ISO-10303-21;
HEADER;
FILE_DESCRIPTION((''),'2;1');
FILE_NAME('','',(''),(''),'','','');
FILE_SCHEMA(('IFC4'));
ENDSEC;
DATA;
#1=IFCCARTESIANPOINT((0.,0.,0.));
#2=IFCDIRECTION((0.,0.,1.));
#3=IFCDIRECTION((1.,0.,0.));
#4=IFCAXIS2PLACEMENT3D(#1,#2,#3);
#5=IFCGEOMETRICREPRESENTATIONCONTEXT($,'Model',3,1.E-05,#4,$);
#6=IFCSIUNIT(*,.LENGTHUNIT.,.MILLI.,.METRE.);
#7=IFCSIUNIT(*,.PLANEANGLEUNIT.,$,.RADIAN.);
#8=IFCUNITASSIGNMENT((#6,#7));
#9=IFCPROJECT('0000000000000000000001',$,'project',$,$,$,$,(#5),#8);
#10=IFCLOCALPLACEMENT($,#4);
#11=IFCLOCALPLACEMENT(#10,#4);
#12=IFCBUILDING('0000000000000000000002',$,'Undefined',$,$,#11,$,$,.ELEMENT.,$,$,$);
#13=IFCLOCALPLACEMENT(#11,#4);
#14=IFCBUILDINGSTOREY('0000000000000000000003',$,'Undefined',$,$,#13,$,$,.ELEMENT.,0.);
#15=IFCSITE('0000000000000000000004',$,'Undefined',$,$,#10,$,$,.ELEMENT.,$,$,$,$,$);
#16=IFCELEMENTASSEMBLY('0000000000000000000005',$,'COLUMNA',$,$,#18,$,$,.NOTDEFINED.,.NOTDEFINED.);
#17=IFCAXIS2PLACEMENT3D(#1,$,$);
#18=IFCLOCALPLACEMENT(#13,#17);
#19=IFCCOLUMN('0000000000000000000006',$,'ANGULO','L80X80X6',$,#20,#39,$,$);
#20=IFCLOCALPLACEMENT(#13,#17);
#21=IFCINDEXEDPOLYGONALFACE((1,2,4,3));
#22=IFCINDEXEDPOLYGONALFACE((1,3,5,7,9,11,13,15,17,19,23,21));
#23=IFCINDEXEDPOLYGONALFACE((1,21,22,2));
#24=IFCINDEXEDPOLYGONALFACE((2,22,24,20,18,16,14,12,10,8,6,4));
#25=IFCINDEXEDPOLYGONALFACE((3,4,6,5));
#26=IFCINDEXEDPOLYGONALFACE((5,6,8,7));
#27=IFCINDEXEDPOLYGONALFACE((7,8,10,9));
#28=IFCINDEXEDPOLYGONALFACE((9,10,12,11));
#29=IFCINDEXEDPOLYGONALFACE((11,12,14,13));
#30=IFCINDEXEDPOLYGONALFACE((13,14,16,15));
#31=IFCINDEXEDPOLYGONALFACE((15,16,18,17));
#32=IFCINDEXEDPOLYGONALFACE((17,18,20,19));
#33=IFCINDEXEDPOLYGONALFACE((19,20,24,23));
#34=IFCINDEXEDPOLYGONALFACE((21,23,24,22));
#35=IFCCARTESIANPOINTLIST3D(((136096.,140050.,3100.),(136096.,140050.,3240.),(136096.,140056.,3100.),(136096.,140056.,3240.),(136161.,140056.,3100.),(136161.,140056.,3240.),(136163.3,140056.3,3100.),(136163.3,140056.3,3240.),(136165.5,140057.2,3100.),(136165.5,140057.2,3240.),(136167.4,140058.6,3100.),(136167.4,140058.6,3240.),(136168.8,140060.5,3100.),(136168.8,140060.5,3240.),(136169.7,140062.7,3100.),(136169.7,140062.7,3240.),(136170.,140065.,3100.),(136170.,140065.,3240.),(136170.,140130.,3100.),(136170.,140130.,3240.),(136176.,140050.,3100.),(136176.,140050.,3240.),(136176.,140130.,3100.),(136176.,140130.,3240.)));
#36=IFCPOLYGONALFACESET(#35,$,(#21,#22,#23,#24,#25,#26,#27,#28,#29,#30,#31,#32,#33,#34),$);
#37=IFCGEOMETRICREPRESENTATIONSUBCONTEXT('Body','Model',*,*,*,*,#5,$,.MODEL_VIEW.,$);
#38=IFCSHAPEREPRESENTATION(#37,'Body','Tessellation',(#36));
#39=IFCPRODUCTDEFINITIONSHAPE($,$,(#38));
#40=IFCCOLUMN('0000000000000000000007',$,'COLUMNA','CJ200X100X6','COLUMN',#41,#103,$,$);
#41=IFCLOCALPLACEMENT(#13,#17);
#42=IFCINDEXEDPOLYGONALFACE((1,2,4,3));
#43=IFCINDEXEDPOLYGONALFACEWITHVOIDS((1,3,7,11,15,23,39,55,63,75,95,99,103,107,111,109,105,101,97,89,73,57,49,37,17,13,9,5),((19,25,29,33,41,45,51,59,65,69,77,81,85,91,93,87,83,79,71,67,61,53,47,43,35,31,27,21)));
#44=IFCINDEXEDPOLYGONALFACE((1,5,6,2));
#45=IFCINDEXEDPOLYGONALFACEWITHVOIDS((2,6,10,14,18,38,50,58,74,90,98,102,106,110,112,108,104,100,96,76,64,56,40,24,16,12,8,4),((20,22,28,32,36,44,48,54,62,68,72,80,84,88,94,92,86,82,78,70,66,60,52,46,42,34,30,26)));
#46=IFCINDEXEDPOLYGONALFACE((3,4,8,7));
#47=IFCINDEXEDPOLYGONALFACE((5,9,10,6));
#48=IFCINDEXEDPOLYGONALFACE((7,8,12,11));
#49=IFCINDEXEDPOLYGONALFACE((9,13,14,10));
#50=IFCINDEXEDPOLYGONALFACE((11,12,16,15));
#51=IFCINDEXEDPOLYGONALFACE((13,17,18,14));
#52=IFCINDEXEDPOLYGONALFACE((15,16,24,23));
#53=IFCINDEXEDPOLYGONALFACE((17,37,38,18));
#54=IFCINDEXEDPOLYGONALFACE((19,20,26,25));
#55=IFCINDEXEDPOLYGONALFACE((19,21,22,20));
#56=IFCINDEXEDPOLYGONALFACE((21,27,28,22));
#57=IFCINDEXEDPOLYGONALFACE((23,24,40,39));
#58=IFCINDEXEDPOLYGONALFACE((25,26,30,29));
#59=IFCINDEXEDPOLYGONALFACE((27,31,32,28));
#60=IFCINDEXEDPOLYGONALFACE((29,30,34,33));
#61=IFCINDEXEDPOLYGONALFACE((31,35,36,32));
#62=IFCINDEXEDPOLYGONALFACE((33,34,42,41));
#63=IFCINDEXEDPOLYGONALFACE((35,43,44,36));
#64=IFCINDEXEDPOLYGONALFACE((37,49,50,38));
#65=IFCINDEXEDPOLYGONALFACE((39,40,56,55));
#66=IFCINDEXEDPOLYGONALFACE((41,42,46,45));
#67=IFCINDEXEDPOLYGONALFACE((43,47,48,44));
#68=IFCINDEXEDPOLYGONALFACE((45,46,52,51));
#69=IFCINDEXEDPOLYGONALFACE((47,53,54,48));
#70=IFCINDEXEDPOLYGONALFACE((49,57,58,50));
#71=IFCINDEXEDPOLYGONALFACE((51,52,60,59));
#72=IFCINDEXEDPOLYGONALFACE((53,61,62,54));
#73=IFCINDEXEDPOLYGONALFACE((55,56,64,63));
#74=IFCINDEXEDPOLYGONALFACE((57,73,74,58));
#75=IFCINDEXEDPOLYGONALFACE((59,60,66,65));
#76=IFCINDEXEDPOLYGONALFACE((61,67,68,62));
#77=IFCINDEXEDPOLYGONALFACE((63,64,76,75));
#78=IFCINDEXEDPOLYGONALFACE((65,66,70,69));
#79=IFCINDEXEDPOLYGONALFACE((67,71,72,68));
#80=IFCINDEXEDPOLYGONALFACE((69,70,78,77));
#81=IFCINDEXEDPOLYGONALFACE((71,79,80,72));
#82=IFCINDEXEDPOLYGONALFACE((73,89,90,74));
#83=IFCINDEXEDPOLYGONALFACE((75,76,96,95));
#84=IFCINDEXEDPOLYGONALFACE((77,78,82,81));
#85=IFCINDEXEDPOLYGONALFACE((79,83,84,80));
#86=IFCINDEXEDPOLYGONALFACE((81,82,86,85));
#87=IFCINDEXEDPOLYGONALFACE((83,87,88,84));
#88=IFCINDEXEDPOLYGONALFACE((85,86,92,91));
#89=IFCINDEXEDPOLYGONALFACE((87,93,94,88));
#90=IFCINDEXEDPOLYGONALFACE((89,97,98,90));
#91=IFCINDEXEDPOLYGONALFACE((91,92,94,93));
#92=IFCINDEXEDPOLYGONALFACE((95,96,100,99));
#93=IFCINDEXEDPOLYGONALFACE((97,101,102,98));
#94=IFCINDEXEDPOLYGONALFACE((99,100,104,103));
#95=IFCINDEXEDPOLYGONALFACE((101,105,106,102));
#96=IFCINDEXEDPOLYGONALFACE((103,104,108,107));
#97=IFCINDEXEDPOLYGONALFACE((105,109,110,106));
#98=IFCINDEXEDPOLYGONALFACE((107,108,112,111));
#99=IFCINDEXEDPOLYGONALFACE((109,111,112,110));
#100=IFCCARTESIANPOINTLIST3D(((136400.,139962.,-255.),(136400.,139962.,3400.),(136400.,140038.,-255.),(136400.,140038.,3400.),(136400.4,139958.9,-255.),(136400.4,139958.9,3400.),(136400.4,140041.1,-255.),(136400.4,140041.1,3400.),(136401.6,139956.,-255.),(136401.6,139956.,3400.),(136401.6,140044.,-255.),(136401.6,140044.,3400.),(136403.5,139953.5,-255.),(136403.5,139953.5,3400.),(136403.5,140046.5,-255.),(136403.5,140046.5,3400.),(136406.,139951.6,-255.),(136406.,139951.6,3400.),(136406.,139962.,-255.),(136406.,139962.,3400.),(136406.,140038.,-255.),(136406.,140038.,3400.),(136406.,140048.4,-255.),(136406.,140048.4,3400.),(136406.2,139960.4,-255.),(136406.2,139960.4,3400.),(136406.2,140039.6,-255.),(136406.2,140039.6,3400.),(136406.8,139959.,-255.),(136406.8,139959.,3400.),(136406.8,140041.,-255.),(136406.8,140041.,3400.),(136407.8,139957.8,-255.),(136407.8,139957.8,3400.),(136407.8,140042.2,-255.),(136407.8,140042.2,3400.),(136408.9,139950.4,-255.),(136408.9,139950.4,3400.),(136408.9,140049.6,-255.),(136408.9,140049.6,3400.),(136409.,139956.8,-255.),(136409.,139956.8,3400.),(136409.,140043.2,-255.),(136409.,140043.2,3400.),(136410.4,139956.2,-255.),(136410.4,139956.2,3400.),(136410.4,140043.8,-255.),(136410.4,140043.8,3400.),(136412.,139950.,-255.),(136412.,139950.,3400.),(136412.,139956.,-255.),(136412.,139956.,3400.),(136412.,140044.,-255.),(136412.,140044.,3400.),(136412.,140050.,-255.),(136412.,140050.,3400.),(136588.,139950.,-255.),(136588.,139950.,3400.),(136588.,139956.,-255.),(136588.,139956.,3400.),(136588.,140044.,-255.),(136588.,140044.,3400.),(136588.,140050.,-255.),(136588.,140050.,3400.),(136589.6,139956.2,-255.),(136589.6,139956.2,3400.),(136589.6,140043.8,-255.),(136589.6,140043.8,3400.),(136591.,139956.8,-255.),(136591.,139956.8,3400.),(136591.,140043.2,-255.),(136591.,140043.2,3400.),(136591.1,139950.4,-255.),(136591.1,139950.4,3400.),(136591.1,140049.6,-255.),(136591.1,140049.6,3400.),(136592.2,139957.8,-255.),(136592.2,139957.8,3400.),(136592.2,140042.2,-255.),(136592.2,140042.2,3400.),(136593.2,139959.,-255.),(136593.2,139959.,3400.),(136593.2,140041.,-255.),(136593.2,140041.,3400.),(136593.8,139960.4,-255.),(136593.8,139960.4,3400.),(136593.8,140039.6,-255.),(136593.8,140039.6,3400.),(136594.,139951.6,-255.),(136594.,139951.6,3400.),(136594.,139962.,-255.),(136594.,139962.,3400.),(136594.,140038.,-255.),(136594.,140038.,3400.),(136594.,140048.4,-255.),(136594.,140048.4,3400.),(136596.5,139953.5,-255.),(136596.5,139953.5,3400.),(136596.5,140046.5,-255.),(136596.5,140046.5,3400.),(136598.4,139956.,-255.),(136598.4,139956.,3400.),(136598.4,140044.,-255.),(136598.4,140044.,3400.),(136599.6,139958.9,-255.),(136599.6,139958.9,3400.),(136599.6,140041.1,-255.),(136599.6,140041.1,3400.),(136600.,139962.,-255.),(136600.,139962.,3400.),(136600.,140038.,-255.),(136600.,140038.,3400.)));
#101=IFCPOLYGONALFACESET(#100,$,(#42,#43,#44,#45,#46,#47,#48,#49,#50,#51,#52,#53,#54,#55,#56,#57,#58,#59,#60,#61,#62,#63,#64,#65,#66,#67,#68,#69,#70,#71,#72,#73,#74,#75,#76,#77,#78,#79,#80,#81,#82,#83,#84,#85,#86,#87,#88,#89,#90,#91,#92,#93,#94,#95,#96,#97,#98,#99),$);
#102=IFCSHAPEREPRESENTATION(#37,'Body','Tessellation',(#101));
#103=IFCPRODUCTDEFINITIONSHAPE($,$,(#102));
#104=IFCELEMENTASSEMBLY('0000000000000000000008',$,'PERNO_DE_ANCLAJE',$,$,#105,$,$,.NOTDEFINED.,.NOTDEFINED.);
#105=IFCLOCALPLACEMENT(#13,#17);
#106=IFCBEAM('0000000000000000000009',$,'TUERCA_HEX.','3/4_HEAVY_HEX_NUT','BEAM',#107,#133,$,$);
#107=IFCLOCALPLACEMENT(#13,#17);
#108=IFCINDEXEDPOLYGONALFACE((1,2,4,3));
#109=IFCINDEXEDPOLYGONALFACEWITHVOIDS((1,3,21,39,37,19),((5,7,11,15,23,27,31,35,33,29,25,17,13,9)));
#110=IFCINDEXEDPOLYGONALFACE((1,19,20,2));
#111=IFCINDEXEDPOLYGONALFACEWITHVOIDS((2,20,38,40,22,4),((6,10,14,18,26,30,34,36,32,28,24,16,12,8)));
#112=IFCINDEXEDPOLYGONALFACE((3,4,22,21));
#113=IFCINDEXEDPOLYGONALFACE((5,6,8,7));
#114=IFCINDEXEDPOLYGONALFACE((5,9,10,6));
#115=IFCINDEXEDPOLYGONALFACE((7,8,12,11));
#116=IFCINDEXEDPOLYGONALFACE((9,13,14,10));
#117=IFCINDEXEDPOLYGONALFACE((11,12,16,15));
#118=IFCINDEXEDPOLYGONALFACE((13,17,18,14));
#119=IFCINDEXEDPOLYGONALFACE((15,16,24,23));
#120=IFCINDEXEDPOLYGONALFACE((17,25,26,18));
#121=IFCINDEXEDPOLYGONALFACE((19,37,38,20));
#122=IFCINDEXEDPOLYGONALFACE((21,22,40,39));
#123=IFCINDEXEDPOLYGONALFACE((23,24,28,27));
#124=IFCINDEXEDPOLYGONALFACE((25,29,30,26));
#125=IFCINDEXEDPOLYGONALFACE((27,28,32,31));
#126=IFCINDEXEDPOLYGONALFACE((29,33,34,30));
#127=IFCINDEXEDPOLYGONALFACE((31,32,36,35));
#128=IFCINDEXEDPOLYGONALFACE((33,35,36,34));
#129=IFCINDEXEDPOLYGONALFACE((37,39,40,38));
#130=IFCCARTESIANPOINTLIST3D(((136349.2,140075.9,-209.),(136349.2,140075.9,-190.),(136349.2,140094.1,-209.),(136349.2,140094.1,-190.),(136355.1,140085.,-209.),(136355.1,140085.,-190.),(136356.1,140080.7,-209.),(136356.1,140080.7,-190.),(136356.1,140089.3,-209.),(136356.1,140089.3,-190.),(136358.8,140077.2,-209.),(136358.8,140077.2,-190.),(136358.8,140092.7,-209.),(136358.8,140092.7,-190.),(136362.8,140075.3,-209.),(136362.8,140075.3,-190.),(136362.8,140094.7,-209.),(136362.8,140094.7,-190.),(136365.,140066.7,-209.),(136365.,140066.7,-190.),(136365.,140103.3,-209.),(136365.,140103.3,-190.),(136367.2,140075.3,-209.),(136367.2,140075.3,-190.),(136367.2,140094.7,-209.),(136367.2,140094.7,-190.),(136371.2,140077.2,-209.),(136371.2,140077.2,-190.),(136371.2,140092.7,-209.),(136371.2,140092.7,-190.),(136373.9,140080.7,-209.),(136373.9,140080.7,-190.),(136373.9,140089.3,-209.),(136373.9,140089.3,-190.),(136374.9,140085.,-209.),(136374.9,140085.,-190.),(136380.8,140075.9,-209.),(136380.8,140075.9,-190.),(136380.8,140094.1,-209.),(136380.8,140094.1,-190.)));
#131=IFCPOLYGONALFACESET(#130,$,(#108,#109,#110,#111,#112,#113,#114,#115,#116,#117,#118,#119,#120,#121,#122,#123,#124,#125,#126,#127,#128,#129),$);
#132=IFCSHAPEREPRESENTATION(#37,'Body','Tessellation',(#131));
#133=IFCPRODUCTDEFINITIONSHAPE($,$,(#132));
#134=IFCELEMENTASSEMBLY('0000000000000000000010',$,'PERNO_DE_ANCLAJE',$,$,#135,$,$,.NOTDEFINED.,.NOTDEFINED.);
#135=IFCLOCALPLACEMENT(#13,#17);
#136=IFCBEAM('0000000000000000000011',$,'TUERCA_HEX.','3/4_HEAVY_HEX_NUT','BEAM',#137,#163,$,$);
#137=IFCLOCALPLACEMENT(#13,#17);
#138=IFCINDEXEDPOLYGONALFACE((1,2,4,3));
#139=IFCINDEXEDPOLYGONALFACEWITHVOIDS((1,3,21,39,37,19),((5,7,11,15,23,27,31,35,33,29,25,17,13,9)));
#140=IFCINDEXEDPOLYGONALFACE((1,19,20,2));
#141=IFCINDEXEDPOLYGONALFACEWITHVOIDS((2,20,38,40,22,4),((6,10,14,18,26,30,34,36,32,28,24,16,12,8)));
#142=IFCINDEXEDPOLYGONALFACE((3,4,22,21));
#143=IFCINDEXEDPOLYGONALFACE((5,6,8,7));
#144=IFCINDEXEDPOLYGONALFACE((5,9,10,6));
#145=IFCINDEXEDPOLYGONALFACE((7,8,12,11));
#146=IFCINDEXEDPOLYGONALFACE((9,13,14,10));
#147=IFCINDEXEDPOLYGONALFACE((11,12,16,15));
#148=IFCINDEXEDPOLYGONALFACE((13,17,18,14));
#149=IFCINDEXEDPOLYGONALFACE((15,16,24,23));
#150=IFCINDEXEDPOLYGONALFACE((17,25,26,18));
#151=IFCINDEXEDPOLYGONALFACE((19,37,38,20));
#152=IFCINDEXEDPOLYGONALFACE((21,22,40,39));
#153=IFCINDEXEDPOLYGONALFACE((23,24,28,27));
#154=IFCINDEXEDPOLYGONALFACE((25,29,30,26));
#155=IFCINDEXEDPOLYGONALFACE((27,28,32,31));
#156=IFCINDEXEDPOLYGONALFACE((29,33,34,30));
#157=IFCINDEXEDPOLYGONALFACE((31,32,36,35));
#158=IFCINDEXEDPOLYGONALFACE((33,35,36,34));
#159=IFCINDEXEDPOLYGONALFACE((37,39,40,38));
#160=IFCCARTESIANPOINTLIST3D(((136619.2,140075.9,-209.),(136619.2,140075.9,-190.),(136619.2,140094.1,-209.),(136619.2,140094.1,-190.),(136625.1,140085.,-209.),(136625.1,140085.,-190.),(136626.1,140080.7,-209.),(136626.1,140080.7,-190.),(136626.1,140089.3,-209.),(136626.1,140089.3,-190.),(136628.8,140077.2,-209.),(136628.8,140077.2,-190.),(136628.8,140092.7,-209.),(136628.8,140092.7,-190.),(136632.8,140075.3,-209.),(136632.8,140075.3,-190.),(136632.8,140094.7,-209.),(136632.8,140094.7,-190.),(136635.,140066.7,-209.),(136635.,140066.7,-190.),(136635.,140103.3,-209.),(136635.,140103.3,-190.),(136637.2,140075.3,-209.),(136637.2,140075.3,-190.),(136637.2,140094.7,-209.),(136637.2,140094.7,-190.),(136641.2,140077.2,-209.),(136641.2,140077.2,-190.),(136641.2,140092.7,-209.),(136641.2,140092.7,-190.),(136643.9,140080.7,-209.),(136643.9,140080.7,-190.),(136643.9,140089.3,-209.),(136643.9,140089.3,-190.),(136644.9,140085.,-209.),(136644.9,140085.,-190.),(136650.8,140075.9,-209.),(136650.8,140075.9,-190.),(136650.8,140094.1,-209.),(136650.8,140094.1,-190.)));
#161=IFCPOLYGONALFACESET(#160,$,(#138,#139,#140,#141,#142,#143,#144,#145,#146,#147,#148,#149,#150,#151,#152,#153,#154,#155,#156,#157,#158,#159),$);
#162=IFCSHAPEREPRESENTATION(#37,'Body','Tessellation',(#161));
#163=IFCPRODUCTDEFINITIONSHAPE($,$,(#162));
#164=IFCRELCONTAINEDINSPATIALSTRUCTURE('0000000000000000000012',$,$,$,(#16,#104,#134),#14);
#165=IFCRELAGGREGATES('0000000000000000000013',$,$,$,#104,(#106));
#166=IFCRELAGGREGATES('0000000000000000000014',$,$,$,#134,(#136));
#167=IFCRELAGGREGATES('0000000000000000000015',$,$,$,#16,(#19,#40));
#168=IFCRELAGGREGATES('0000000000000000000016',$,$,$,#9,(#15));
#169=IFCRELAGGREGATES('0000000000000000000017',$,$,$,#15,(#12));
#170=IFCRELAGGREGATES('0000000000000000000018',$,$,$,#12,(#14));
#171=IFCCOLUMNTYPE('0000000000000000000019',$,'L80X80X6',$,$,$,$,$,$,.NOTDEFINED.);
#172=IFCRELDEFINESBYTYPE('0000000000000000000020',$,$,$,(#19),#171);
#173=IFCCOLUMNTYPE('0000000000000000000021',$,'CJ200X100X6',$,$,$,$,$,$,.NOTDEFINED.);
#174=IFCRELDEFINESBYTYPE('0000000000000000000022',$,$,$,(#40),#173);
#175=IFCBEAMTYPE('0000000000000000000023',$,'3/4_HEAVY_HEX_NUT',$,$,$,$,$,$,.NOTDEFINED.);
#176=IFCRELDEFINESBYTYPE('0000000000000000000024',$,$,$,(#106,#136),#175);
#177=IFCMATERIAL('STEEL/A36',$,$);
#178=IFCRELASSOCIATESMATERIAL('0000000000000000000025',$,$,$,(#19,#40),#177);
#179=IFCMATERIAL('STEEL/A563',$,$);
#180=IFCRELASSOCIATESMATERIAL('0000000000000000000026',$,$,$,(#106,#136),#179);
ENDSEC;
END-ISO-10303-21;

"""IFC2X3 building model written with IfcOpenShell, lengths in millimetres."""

from ifc_helpers import new_model, si_unit, frame, origin_with_axes, origin_2d_with_axis, place, context, subcontext, project, spatial, polyline, hollow_rectangle, l_section, outline, extrude, material, type_object, element, aggregate, save


model = new_model("IFC2X3")

# Units and contexts
model_context = context("Model", 3, precision=1e-05, world=origin_with_axes())
body_context = subcontext(model_context, "Body", "Model", "MODEL_VIEW")
ifc_project = project(units=[si_unit("LENGTHUNIT", "METRE", prefix="MILLI"), si_unit("PLANEANGLEUNIT", "RADIAN")], contexts=[model_context])

# Site, building, storey
site_placement = place(None, origin_with_axes())
site = spatial("IfcSite", under=ifc_project, at=site_placement, Name="Undefined", CompositionType="ELEMENT")
building_placement = place(site_placement, origin_with_axes())
building = spatial("IfcBuilding", under=site, at=building_placement, Name="Undefined", CompositionType="ELEMENT")
storey_placement = place(building_placement, origin_with_axes())
storey = spatial("IfcBuildingStorey", under=building, at=storey_placement, Name="Undefined", CompositionType="ELEMENT", Elevation=0.0)

# Element assembly, columns
assembly_1_placement = place(storey_placement, origin_with_axes())
assembly_1 = element("IfcElementAssembly", 1, at=assembly_1_placement, inside=storey, Name="COLUMNA", AssemblyPlace="NOTDEFINED", PredefinedType="NOTDEFINED")
ifc_material_1 = material(Name="STEEL/A36")
column_type_1 = type_object("IfcColumnType", Name="L80X80X6", PredefinedType="NOTDEFINED")
column_1_placement = place(assembly_1_placement, frame((136136.0, 140090.0, 3100.0), z_axis=(0.0, 0.0, 1.0), x_axis=(0.0, 1.0, 0.0)))
column_1 = element("IfcColumn", 2, at=column_1_placement, type_object=column_type_1, material=ifc_material_1, Name="ANGULO", Description="L80X80X6", context=body_context, shape_type="SweptSolid", body=[
    extrude(l_section(Depth=80.0, Width=80.0, Thickness=6.0, FilletRadius=9.0, at=origin_2d_with_axis()), frame((0.0, 0.0, 140.0), z_axis=(0.0, 0.0, -1.0), x_axis=(0.0, 1.0, 0.0)), (0.0, 0.0, 1.0), 140.0),
])
column_type_2 = type_object("IfcColumnType", Name="CJ200X100X6", PredefinedType="NOTDEFINED")
column_2_placement = place(assembly_1_placement, frame((136500.0, 140000.0, -255.0), z_axis=(0.0, 0.0, 1.0), x_axis=(-1.0, 0.0, 0.0)))
column_2 = element("IfcColumn", 3, at=column_2_placement, type_object=column_type_2, material=ifc_material_1, Name="COLUMNA", Description="CJ200X100X6", ObjectType="COLUMN", context=body_context, shape_type="SweptSolid", body=[
    extrude(hollow_rectangle(XDim=100.0, YDim=200.0, WallThickness=6.0, InnerFilletRadius=6.0, OuterFilletRadius=12.0, at=origin_2d_with_axis()), frame((0.0, 0.0, 3655.0), z_axis=(0.0, 0.0, -1.0), x_axis=(0.0, 1.0, 0.0)), (0.0, 0.0, 1.0), 3655.0),
])

# Element assemblies, beams
assembly_2_placement = place(storey_placement, origin_with_axes())
assembly_2 = element("IfcElementAssembly", 4, at=assembly_2_placement, inside=storey, Name="PERNO_DE_ANCLAJE", AssemblyPlace="NOTDEFINED", PredefinedType="NOTDEFINED")
ifc_material_2 = material(Name="STEEL/A563")
beam_type_1 = type_object("IfcBeamType", Name="3/4_HEAVY_HEX_NUT", PredefinedType="NOTDEFINED")
beam_1_placement = place(assembly_2_placement, frame((136365.0, 140085.0, -190.0), z_axis=(1.0, 0.0, 0.0), x_axis=(0.0, 0.0, -1.0)))
beam_1 = element("IfcBeam", 5, at=beam_1_placement, type_object=beam_type_1, material=ifc_material_2, Name="TUERCA_HEX.", Description="3/4_HEAVY_HEX_NUT", ObjectType="BEAM", context=body_context, shape_type="SweptSolid", body=[
    extrude(outline(polyline([(-9.1, -15.8), (-18.3, 0.0), (-9.1, 15.8), (9.1, 15.8), (18.3, 0.0), (9.1, -15.8), (-9.1, -15.8)]), holes=[polyline([(7.8, 6.2), (4.3, 8.9), (0.0, 9.9), (-4.3, 8.9), (-7.8, 6.2), (-9.7, 2.2), (-9.7, -2.2), (-7.8, -6.2), (-4.3, -8.9), (0.0, -9.9), (4.3, -8.9), (7.8, -6.2), (9.7, -2.2), (9.7, 2.2), (7.8, 6.2)])]), frame((19.0, 0.0, 0.0), z_axis=(-1.0, 0.0, 0.0), x_axis=(0.0, -1.0, 0.0)), (0.0, 0.0, 1.0), 19.0),
])
assembly_3_placement = place(storey_placement, origin_with_axes())
assembly_3 = element("IfcElementAssembly", 6, at=assembly_3_placement, inside=storey, Name="PERNO_DE_ANCLAJE", AssemblyPlace="NOTDEFINED", PredefinedType="NOTDEFINED")
beam_2_placement = place(assembly_3_placement, frame((136635.0, 140085.0, -190.0), z_axis=(1.0, 0.0, 0.0), x_axis=(0.0, 0.0, -1.0)))
beam_2 = element("IfcBeam", 7, at=beam_2_placement, type_object=beam_type_1, material=ifc_material_2, Name="TUERCA_HEX.", Description="3/4_HEAVY_HEX_NUT", ObjectType="BEAM", context=body_context, shape_type="SweptSolid", body=[
    extrude(outline(polyline([(-9.1, -15.8), (-18.3, 0.0), (-9.1, 15.8), (9.1, 15.8), (18.3, 0.0), (9.1, -15.8), (-9.1, -15.8)]), holes=[polyline([(7.8, 6.2), (4.3, 8.9), (0.0, 9.9), (-4.3, 8.9), (-7.8, 6.2), (-9.7, 2.2), (-9.7, -2.2), (-7.8, -6.2), (-4.3, -8.9), (0.0, -9.9), (4.3, -8.9), (7.8, -6.2), (9.7, -2.2), (9.7, 2.2), (7.8, 6.2)])]), frame((19.0, 0.0, 0.0), z_axis=(-1.0, 0.0, 0.0), x_axis=(0.0, -1.0, 0.0)), (0.0, 0.0, 1.0), 19.0),
])

aggregate(assembly_2, [beam_1])
aggregate(assembly_3, [beam_2])

aggregate(assembly_1, [column_1, column_2])

save(model, "model.ifc")
